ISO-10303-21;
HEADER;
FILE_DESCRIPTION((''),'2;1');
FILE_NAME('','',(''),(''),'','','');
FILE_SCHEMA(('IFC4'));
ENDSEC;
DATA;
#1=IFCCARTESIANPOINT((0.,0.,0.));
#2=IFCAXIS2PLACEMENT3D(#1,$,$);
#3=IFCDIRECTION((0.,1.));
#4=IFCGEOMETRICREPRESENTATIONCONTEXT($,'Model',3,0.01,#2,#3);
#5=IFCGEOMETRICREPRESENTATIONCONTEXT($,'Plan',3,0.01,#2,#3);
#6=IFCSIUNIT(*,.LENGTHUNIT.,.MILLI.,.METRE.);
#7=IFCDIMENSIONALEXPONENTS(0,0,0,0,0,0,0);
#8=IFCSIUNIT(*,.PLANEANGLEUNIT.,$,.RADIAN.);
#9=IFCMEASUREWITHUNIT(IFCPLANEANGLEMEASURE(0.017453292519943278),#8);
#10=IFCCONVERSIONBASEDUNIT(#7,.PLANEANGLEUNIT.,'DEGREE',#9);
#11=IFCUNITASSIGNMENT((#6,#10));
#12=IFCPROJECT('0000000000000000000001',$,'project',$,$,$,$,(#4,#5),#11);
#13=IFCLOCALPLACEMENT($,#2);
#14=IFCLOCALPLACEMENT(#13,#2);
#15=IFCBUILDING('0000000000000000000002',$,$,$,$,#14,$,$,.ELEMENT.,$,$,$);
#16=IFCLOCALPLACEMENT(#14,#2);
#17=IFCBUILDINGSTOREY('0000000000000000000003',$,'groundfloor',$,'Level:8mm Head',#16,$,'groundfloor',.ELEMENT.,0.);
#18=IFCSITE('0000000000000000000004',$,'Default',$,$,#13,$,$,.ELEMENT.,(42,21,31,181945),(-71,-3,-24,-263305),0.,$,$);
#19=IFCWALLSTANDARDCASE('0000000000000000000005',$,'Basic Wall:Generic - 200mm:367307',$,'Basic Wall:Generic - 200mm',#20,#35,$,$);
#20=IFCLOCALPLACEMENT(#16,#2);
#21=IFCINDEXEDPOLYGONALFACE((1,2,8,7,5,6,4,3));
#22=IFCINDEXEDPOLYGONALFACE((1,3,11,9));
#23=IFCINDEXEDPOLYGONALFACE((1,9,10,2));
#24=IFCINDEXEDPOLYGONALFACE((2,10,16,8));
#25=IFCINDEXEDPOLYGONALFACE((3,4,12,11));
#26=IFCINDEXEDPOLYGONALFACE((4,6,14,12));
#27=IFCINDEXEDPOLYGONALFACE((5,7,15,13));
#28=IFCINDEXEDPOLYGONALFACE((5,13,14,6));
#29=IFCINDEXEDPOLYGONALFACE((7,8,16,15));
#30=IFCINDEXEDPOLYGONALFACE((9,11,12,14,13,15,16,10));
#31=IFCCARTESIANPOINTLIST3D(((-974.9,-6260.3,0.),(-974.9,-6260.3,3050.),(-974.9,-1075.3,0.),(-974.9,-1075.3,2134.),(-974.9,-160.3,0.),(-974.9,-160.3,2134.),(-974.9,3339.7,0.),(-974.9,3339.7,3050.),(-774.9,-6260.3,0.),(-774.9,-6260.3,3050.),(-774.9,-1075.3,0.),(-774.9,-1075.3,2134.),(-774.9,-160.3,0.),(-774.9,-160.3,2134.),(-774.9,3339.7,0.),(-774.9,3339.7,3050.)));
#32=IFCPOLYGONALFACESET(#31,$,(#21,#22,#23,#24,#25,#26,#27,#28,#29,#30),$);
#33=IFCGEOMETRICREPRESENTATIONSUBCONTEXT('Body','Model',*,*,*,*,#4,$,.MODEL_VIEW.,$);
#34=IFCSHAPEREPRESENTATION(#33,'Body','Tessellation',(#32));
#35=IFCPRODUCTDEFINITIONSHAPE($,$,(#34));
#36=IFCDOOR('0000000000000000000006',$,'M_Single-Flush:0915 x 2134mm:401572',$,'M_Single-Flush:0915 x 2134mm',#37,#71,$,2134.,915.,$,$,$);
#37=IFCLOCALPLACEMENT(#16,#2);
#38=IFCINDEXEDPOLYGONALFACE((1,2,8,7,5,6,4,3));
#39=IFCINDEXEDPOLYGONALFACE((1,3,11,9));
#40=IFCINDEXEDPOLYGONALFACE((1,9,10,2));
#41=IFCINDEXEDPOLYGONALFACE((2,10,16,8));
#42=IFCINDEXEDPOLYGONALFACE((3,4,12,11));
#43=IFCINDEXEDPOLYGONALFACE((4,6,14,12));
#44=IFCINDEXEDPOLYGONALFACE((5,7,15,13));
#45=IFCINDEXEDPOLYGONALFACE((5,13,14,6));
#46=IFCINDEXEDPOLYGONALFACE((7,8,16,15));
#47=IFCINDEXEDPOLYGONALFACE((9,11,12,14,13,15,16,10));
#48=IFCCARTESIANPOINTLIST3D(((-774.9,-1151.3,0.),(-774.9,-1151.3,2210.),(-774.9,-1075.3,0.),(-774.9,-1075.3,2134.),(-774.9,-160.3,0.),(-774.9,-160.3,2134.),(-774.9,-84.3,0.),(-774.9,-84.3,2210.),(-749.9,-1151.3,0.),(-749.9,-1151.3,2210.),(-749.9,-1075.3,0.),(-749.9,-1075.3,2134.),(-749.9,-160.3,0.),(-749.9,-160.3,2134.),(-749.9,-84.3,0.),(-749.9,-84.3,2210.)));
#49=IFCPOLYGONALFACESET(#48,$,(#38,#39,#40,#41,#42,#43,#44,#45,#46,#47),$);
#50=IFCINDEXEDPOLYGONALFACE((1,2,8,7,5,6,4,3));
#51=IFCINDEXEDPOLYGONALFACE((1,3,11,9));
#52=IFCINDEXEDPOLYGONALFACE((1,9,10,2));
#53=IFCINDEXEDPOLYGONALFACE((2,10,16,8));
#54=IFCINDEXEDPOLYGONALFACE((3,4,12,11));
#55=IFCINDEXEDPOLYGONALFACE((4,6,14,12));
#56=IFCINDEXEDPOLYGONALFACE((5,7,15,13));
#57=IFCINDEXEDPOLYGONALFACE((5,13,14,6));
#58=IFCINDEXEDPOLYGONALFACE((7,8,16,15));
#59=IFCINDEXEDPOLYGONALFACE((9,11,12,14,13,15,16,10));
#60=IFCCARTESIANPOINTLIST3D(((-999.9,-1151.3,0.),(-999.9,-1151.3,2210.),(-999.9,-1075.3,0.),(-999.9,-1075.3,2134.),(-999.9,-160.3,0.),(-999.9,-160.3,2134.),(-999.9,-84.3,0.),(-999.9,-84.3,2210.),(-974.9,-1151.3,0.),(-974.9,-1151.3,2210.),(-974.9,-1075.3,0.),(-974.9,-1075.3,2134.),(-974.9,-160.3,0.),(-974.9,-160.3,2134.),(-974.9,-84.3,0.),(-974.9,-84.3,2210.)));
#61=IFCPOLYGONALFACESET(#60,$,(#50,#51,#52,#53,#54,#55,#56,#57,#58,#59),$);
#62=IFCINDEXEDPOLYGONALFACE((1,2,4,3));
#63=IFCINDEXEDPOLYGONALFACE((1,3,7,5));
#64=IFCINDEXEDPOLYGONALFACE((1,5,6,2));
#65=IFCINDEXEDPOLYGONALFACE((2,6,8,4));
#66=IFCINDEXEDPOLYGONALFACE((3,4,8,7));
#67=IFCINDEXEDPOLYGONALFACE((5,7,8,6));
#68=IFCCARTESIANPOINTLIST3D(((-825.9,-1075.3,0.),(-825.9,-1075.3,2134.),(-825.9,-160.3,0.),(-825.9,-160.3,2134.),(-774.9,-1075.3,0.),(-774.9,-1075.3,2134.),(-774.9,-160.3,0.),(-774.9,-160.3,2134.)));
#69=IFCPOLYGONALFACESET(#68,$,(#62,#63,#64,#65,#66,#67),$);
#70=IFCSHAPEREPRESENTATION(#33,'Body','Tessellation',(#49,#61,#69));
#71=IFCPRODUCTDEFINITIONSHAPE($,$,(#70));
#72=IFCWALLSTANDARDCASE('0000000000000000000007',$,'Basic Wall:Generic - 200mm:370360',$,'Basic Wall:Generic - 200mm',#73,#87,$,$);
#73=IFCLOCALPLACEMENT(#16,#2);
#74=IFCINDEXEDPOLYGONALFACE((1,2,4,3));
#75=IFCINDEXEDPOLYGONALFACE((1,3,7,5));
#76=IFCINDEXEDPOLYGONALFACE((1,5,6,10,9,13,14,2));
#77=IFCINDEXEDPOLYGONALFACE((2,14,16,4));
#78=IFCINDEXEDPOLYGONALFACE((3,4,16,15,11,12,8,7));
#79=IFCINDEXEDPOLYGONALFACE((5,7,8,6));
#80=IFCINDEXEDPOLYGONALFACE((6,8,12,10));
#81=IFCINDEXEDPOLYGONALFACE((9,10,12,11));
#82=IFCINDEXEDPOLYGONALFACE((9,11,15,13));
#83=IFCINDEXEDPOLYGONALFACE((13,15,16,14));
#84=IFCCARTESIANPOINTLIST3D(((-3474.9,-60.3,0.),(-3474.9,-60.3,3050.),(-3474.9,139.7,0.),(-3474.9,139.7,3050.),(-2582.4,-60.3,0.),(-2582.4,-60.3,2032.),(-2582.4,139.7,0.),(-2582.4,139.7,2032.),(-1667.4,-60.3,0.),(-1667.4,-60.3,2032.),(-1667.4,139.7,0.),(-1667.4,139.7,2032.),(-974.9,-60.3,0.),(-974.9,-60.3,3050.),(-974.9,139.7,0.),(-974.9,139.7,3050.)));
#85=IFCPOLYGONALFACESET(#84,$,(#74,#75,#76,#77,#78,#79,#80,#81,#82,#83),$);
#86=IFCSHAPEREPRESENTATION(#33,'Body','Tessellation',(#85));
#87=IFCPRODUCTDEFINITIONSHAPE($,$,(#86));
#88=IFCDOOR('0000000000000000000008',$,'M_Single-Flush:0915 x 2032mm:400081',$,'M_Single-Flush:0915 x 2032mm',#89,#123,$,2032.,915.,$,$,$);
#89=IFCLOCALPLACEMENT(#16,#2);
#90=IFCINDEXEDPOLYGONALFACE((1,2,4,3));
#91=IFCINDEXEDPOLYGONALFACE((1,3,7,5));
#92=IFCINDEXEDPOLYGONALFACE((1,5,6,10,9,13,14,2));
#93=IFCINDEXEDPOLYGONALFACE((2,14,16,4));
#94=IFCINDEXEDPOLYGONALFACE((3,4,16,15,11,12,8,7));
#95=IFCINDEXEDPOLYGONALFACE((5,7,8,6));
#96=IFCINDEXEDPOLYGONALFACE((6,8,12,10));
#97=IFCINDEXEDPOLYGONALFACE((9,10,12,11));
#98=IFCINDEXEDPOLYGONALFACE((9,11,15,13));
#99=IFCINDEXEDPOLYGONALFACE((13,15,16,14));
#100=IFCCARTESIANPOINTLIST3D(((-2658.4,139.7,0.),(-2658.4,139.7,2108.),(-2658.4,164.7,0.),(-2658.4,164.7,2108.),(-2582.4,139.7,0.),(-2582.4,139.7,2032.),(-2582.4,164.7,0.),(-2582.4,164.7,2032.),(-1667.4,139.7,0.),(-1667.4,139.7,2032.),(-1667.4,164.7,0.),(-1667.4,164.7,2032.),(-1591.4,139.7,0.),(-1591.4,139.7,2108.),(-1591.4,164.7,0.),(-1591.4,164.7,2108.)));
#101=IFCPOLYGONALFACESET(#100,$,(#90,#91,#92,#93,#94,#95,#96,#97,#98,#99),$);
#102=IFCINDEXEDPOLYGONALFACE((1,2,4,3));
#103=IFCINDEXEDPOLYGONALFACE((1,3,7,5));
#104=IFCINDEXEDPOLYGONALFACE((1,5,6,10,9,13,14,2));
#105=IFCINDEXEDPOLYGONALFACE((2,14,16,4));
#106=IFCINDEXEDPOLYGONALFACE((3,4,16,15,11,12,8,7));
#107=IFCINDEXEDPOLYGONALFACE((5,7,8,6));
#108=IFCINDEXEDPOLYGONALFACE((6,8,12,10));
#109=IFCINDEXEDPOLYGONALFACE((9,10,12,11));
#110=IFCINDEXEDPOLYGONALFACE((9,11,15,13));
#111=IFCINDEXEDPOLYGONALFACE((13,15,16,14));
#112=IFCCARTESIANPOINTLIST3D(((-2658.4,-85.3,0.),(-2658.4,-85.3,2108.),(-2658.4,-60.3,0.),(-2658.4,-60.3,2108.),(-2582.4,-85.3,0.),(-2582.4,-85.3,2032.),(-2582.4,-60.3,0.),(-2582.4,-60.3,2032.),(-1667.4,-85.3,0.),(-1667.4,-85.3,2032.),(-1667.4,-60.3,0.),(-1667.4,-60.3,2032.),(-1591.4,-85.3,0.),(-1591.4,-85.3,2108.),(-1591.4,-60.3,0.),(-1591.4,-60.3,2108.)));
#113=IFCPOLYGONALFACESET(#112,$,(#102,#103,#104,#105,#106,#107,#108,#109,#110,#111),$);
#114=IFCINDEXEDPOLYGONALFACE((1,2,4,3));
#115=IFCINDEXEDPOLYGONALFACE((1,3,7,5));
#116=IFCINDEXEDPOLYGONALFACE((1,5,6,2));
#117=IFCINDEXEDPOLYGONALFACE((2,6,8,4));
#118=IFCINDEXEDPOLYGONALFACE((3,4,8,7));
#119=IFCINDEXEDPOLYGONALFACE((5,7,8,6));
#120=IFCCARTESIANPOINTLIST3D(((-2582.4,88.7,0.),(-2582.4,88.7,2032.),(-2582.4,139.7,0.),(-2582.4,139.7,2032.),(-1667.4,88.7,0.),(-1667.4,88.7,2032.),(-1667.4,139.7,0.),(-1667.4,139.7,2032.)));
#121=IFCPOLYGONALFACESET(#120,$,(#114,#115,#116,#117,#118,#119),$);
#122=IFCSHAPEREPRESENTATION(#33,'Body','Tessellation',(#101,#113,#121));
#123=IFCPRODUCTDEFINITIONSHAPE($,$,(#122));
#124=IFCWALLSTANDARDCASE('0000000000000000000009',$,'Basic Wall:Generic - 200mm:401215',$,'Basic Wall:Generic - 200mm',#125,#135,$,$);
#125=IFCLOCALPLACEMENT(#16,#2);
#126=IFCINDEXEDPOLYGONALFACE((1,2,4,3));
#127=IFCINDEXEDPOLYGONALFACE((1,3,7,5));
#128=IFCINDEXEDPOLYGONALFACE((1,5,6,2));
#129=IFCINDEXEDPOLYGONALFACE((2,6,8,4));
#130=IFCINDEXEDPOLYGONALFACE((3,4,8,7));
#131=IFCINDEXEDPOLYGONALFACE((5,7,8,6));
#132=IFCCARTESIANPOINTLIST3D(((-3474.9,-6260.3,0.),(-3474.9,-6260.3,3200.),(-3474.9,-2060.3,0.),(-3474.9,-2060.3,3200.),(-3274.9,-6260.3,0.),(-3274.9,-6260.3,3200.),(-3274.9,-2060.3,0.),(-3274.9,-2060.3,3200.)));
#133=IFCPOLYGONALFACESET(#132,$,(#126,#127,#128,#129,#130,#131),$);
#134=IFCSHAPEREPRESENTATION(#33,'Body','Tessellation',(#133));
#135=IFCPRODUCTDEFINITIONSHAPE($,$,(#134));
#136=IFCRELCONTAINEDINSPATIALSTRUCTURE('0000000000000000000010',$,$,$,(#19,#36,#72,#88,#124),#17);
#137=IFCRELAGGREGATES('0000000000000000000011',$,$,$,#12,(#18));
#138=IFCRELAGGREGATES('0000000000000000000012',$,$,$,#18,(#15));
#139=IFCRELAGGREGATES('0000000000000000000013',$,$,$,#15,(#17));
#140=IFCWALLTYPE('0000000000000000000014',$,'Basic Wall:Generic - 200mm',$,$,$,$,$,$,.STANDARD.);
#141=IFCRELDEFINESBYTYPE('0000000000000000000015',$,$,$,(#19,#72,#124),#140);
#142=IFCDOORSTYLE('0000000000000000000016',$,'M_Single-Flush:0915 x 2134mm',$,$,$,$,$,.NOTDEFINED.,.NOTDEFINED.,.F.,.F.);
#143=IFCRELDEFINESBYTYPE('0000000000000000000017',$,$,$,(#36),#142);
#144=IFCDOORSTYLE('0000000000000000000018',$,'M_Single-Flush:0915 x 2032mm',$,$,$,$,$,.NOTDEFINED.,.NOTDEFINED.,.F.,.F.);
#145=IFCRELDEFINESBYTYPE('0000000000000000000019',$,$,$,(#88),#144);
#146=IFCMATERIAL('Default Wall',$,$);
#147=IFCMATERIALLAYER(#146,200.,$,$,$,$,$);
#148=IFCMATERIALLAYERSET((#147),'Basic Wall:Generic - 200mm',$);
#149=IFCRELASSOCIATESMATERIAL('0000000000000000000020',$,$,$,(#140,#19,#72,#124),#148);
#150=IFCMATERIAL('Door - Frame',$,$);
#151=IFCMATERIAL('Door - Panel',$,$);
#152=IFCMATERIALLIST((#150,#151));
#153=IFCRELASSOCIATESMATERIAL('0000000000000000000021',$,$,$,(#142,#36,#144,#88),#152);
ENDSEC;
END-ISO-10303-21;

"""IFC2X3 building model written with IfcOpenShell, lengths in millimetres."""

from ifc_helpers import new_model, entity, si_unit, converted_unit, direction, frame, frame_2d, origin, place, context, subcontext, project, spatial, polyline, rectangle, outline, extrude, clip, bounded_halfspace, source, transform, mapped, material, material_list, layer, layer_set, layer_usage, type_object, type_shapes, element, fill, save


model = new_model("IFC2X3")

# Units and contexts
model_context = context("Model", 3, precision=0.01, world=origin(), true_north=direction((0.0, 1.0)))
plan_context = context("Plan", 3, precision=0.01, world=origin(), true_north=direction((0.0, 1.0)))
body_context = subcontext(model_context, "Body", "Model", "MODEL_VIEW")
ifc_project = project(units=[si_unit("LENGTHUNIT", "METRE", prefix="MILLI"), converted_unit("PLANEANGLEUNIT", "DEGREE", entity("IfcPlaneAngleMeasure", 0.017453292519943278), si_unit("PLANEANGLEUNIT", "RADIAN"), dimensions=[0, 0, 0, 0, 0, 0, 0])], contexts=[model_context, plan_context])

# Site, building, storey
site_placement = place(None, origin())
site = spatial("IfcSite", under=ifc_project, at=site_placement, Name="Default", CompositionType="ELEMENT", RefLatitude=(42, 21, 31, 181945), RefLongitude=(-71, -3, -24, -263305), RefElevation=0.0)
building_placement = place(site_placement, origin())
building = spatial("IfcBuilding", under=site, at=building_placement, CompositionType="ELEMENT")
storey_placement = place(building_placement, origin())
storey = spatial("IfcBuildingStorey", under=building, at=storey_placement, Name="groundfloor", ObjectType="Level:8mm Head", LongName="groundfloor", CompositionType="ELEMENT", Elevation=0.0)

# Shared definitions
ifc_material_1 = material(Name="Default Wall")

# Shared definitions
ifc_layer_1 = layer(ifc_material_1, 200.0)
ifc_layer_set_1 = layer_set([ifc_layer_1], Name="Basic Wall:Generic - 200mm")
ifc_layer_usage_1 = layer_usage(ifc_layer_set_1, "AXIS2", "NEGATIVE", 100.0)
wall_type_1 = type_object("IfcWallType", Name="Basic Wall:Generic - 200mm", PredefinedType="STANDARD", material=ifc_layer_set_1)

# Walls, openings, doors
wall_1_placement = place(storey_placement, frame((-874.9, -6260.3, 0.0), z_axis=(0.0, 0.0, 1.0), x_axis=(0.0, 1.0, 0.0)))
wall_1 = element("IfcWallStandardCase", 1, at=wall_1_placement, inside=storey, type_object=wall_type_1, material=ifc_layer_usage_1, Name="Basic Wall:Generic - 200mm:367307", ObjectType="Basic Wall:Generic - 200mm", context=body_context, shape_type="Clipping", body=[
    clip(extrude(rectangle(XDim=9600.0, YDim=200.0, at=frame_2d((4800.0, 0.0), x_axis=(-1.0, 0.0))), origin(), (0.0, 0.0, 1.0), 3050.0), bounded_halfspace(frame((9600.0, -100.0, 3050.0), z_axis=(0.0, 0.0, -1.0), x_axis=(-1.0, 0.0, 0.0)), True, frame((9600.0, -100.0, 3050.0)), polyline([(0.0, 0.0), (0.0, 100.0), (0.0, 200.0), (-3200.0, 200.0), (-3400.0, 200.0), (-6605.0, 200.0), (-6605.0, 100.0), (-9600.0, 100.0), (-9600.0, 0.0), (0.0, 0.0)]))),
])
opening_1_placement = place(wall_1_placement, frame((6100.0, 100.0, 0.0)))
opening_1 = element("IfcOpeningElement", 2, at=opening_1_placement, cuts=wall_1, ObjectType="Opening", context=body_context, shape_type="SweptSolid", body=[
    extrude(rectangle(XDim=915.0, YDim=2134.0, at=frame_2d((1067.0, 457.5), x_axis=(0.0, 1.0))), frame((0.0, 0.0, 0.0), z_axis=(0.0, -1.0, 0.0), x_axis=(0.0, 0.0, 1.0)), (0.0, 0.0, 1.0), 200.0),
])
ifc_material_2 = material(Name="Door - Frame")
ifc_material_3 = material(Name="Door - Panel")
ifc_material_list_1 = material_list([ifc_material_2, ifc_material_3])
door_style_1 = type_object("IfcDoorStyle", Name="M_Single-Flush:0915 x 2134mm", ConstructionType="NOTDEFINED", OperationType="NOTDEFINED", ParameterTakesPrecedence=False, Sizeable=False, material=ifc_material_list_1)
shared_shape_1 = source(origin(), body_context, "Body", "SweptSolid", [
    extrude(outline(polyline([(-533.5, -1124.0), (533.5, -1124.0), (533.5, 1086.0), (457.5, 1086.0), (457.5, -1048.0), (-457.5, -1048.0), (-457.5, 1086.0), (-533.5, 1086.0), (-533.5, -1124.0)])), frame((457.5, 200.0, 1086.0), z_axis=(0.0, 1.0, 0.0), x_axis=(1.0, 0.0, 0.0)), (0.0, 0.0, 1.0), 25.0),
    extrude(outline(polyline([(-1124.0, -533.5), (1086.0, -533.5), (1086.0, -457.5), (-1048.0, -457.5), (-1048.0, 457.5), (1086.0, 457.5), (1086.0, 533.5), (-1124.0, 533.5), (-1124.0, -533.5)])), frame((457.5, -25.0, 1086.0), z_axis=(0.0, 1.0, 0.0), x_axis=(0.0, 0.0, -1.0)), (0.0, 0.0, 1.0), 25.0),
    extrude(rectangle(XDim=51.0, YDim=915.0, at=frame_2d((0.0, 0.0), x_axis=(1.0, 0.0))), frame((457.5, 174.5, 0.0), z_axis=(0.0, 0.0, 1.0), x_axis=(0.0, 1.0, 0.0)), (0.0, 0.0, 1.0), 2134.0),
])
type_shapes(door_style_1, [shared_shape_1])
door_1_placement = place(opening_1_placement, frame((0.0, 0.0, 0.0), z_axis=(0.0, 0.0, 1.0), x_axis=(-1.0, 0.0, 0.0)))
door_1 = element("IfcDoor", 3, at=door_1_placement, inside=storey, type_object=door_style_1, material=ifc_material_list_1, Name="M_Single-Flush:0915 x 2134mm:401572", ObjectType="M_Single-Flush:0915 x 2134mm", OverallHeight=2134.0, OverallWidth=915.0, context=body_context, shape_type="MappedRepresentation", body=[
    mapped(shared_shape_1, transform((0.0, 0.0, 0.0), scale=1.0)),
])
fill(opening_1, door_1)
wall_2_placement = place(storey_placement, frame((-3474.9, 39.7, 0.0)))
wall_2 = element("IfcWallStandardCase", 4, at=wall_2_placement, inside=storey, type_object=wall_type_1, material=ifc_layer_usage_1, Name="Basic Wall:Generic - 200mm:370360", ObjectType="Basic Wall:Generic - 200mm", context=body_context, shape_type="Clipping", body=[
    clip(extrude(rectangle(XDim=2500.0, YDim=200.0, at=frame_2d((1250.0, 0.0), x_axis=(1.0, 0.0))), origin(), (0.0, 0.0, 1.0), 3050.0), bounded_halfspace(frame((0.0, -100.0, 3050.0), z_axis=(0.0, 0.0, -1.0), x_axis=(0.0, -1.0, 0.0)), True, frame((0.0, -100.0, 3050.0)), polyline([(0.0, 0.0), (2500.0, 0.0), (2500.0, 200.0), (200.0, 200.0), (0.0, 200.0), (0.0, 0.0)]))),
])
opening_2_placement = place(wall_2_placement, frame((892.5, -100.0, 0.0)))
opening_2 = element("IfcOpeningElement", 5, at=opening_2_placement, cuts=wall_2, ObjectType="Opening", context=body_context, shape_type="SweptSolid", body=[
    extrude(rectangle(XDim=915.0, YDim=2032.0, at=frame_2d((1016.0, 457.5), x_axis=(0.0, 1.0))), frame((0.0, 0.0, 0.0), z_axis=(0.0, 1.0, 0.0), x_axis=(0.0, 0.0, 1.0)), (0.0, 0.0, 1.0), 200.0),
])
door_style_2 = type_object("IfcDoorStyle", Name="M_Single-Flush:0915 x 2032mm", ConstructionType="NOTDEFINED", OperationType="NOTDEFINED", ParameterTakesPrecedence=False, Sizeable=False, material=ifc_material_list_1)
shared_shape_2 = source(origin(), body_context, "Body", "SweptSolid", [
    extrude(outline(polyline([(-533.5, -1073.0), (533.5, -1073.0), (533.5, 1035.0), (457.5, 1035.0), (457.5, -997.0), (-457.5, -997.0), (-457.5, 1035.0), (-533.5, 1035.0), (-533.5, -1073.0)])), frame((457.5, 200.0, 1035.0), z_axis=(0.0, 1.0, 0.0), x_axis=(1.0, 0.0, 0.0)), (0.0, 0.0, 1.0), 25.0),
    extrude(outline(polyline([(-1073.0, -533.5), (1035.0, -533.5), (1035.0, -457.5), (-997.0, -457.5), (-997.0, 457.5), (1035.0, 457.5), (1035.0, 533.5), (-1073.0, 533.5), (-1073.0, -533.5)])), frame((457.5, -25.0, 1035.0), z_axis=(0.0, 1.0, 0.0), x_axis=(0.0, 0.0, -1.0)), (0.0, 0.0, 1.0), 25.0),
    extrude(rectangle(XDim=51.0, YDim=915.0, at=frame_2d((0.0, 0.0), x_axis=(1.0, 0.0))), frame((457.5, 174.5, 0.0), z_axis=(0.0, 0.0, 1.0), x_axis=(0.0, 1.0, 0.0)), (0.0, 0.0, 1.0), 2032.0),
])
type_shapes(door_style_2, [shared_shape_2])
door_2_placement = place(opening_2_placement, origin())
door_2 = element("IfcDoor", 6, at=door_2_placement, inside=storey, type_object=door_style_2, material=ifc_material_list_1, Name="M_Single-Flush:0915 x 2032mm:400081", ObjectType="M_Single-Flush:0915 x 2032mm", OverallHeight=2032.0, OverallWidth=915.0, context=body_context, shape_type="MappedRepresentation", body=[
    mapped(shared_shape_2, transform((0.0, 0.0, 0.0), scale=1.0)),
])
fill(opening_2, door_2)

# Wall
wall_3_placement = place(storey_placement, frame((-3374.9, -6260.3, 0.0), z_axis=(0.0, 0.0, 1.0), x_axis=(0.0, 1.0, 0.0)))
element("IfcWallStandardCase", 7, at=wall_3_placement, inside=storey, type_object=wall_type_1, material=ifc_layer_usage_1, Name="Basic Wall:Generic - 200mm:401215", ObjectType="Basic Wall:Generic - 200mm", context=body_context, shape_type="SweptSolid", body=[
    extrude(rectangle(XDim=4200.0, YDim=200.0, at=frame_2d((2100.0, 0.0), x_axis=(-1.0, 0.0))), origin(), (0.0, 0.0, 1.0), 3200.0),
])

save(model, "model.ifc")
